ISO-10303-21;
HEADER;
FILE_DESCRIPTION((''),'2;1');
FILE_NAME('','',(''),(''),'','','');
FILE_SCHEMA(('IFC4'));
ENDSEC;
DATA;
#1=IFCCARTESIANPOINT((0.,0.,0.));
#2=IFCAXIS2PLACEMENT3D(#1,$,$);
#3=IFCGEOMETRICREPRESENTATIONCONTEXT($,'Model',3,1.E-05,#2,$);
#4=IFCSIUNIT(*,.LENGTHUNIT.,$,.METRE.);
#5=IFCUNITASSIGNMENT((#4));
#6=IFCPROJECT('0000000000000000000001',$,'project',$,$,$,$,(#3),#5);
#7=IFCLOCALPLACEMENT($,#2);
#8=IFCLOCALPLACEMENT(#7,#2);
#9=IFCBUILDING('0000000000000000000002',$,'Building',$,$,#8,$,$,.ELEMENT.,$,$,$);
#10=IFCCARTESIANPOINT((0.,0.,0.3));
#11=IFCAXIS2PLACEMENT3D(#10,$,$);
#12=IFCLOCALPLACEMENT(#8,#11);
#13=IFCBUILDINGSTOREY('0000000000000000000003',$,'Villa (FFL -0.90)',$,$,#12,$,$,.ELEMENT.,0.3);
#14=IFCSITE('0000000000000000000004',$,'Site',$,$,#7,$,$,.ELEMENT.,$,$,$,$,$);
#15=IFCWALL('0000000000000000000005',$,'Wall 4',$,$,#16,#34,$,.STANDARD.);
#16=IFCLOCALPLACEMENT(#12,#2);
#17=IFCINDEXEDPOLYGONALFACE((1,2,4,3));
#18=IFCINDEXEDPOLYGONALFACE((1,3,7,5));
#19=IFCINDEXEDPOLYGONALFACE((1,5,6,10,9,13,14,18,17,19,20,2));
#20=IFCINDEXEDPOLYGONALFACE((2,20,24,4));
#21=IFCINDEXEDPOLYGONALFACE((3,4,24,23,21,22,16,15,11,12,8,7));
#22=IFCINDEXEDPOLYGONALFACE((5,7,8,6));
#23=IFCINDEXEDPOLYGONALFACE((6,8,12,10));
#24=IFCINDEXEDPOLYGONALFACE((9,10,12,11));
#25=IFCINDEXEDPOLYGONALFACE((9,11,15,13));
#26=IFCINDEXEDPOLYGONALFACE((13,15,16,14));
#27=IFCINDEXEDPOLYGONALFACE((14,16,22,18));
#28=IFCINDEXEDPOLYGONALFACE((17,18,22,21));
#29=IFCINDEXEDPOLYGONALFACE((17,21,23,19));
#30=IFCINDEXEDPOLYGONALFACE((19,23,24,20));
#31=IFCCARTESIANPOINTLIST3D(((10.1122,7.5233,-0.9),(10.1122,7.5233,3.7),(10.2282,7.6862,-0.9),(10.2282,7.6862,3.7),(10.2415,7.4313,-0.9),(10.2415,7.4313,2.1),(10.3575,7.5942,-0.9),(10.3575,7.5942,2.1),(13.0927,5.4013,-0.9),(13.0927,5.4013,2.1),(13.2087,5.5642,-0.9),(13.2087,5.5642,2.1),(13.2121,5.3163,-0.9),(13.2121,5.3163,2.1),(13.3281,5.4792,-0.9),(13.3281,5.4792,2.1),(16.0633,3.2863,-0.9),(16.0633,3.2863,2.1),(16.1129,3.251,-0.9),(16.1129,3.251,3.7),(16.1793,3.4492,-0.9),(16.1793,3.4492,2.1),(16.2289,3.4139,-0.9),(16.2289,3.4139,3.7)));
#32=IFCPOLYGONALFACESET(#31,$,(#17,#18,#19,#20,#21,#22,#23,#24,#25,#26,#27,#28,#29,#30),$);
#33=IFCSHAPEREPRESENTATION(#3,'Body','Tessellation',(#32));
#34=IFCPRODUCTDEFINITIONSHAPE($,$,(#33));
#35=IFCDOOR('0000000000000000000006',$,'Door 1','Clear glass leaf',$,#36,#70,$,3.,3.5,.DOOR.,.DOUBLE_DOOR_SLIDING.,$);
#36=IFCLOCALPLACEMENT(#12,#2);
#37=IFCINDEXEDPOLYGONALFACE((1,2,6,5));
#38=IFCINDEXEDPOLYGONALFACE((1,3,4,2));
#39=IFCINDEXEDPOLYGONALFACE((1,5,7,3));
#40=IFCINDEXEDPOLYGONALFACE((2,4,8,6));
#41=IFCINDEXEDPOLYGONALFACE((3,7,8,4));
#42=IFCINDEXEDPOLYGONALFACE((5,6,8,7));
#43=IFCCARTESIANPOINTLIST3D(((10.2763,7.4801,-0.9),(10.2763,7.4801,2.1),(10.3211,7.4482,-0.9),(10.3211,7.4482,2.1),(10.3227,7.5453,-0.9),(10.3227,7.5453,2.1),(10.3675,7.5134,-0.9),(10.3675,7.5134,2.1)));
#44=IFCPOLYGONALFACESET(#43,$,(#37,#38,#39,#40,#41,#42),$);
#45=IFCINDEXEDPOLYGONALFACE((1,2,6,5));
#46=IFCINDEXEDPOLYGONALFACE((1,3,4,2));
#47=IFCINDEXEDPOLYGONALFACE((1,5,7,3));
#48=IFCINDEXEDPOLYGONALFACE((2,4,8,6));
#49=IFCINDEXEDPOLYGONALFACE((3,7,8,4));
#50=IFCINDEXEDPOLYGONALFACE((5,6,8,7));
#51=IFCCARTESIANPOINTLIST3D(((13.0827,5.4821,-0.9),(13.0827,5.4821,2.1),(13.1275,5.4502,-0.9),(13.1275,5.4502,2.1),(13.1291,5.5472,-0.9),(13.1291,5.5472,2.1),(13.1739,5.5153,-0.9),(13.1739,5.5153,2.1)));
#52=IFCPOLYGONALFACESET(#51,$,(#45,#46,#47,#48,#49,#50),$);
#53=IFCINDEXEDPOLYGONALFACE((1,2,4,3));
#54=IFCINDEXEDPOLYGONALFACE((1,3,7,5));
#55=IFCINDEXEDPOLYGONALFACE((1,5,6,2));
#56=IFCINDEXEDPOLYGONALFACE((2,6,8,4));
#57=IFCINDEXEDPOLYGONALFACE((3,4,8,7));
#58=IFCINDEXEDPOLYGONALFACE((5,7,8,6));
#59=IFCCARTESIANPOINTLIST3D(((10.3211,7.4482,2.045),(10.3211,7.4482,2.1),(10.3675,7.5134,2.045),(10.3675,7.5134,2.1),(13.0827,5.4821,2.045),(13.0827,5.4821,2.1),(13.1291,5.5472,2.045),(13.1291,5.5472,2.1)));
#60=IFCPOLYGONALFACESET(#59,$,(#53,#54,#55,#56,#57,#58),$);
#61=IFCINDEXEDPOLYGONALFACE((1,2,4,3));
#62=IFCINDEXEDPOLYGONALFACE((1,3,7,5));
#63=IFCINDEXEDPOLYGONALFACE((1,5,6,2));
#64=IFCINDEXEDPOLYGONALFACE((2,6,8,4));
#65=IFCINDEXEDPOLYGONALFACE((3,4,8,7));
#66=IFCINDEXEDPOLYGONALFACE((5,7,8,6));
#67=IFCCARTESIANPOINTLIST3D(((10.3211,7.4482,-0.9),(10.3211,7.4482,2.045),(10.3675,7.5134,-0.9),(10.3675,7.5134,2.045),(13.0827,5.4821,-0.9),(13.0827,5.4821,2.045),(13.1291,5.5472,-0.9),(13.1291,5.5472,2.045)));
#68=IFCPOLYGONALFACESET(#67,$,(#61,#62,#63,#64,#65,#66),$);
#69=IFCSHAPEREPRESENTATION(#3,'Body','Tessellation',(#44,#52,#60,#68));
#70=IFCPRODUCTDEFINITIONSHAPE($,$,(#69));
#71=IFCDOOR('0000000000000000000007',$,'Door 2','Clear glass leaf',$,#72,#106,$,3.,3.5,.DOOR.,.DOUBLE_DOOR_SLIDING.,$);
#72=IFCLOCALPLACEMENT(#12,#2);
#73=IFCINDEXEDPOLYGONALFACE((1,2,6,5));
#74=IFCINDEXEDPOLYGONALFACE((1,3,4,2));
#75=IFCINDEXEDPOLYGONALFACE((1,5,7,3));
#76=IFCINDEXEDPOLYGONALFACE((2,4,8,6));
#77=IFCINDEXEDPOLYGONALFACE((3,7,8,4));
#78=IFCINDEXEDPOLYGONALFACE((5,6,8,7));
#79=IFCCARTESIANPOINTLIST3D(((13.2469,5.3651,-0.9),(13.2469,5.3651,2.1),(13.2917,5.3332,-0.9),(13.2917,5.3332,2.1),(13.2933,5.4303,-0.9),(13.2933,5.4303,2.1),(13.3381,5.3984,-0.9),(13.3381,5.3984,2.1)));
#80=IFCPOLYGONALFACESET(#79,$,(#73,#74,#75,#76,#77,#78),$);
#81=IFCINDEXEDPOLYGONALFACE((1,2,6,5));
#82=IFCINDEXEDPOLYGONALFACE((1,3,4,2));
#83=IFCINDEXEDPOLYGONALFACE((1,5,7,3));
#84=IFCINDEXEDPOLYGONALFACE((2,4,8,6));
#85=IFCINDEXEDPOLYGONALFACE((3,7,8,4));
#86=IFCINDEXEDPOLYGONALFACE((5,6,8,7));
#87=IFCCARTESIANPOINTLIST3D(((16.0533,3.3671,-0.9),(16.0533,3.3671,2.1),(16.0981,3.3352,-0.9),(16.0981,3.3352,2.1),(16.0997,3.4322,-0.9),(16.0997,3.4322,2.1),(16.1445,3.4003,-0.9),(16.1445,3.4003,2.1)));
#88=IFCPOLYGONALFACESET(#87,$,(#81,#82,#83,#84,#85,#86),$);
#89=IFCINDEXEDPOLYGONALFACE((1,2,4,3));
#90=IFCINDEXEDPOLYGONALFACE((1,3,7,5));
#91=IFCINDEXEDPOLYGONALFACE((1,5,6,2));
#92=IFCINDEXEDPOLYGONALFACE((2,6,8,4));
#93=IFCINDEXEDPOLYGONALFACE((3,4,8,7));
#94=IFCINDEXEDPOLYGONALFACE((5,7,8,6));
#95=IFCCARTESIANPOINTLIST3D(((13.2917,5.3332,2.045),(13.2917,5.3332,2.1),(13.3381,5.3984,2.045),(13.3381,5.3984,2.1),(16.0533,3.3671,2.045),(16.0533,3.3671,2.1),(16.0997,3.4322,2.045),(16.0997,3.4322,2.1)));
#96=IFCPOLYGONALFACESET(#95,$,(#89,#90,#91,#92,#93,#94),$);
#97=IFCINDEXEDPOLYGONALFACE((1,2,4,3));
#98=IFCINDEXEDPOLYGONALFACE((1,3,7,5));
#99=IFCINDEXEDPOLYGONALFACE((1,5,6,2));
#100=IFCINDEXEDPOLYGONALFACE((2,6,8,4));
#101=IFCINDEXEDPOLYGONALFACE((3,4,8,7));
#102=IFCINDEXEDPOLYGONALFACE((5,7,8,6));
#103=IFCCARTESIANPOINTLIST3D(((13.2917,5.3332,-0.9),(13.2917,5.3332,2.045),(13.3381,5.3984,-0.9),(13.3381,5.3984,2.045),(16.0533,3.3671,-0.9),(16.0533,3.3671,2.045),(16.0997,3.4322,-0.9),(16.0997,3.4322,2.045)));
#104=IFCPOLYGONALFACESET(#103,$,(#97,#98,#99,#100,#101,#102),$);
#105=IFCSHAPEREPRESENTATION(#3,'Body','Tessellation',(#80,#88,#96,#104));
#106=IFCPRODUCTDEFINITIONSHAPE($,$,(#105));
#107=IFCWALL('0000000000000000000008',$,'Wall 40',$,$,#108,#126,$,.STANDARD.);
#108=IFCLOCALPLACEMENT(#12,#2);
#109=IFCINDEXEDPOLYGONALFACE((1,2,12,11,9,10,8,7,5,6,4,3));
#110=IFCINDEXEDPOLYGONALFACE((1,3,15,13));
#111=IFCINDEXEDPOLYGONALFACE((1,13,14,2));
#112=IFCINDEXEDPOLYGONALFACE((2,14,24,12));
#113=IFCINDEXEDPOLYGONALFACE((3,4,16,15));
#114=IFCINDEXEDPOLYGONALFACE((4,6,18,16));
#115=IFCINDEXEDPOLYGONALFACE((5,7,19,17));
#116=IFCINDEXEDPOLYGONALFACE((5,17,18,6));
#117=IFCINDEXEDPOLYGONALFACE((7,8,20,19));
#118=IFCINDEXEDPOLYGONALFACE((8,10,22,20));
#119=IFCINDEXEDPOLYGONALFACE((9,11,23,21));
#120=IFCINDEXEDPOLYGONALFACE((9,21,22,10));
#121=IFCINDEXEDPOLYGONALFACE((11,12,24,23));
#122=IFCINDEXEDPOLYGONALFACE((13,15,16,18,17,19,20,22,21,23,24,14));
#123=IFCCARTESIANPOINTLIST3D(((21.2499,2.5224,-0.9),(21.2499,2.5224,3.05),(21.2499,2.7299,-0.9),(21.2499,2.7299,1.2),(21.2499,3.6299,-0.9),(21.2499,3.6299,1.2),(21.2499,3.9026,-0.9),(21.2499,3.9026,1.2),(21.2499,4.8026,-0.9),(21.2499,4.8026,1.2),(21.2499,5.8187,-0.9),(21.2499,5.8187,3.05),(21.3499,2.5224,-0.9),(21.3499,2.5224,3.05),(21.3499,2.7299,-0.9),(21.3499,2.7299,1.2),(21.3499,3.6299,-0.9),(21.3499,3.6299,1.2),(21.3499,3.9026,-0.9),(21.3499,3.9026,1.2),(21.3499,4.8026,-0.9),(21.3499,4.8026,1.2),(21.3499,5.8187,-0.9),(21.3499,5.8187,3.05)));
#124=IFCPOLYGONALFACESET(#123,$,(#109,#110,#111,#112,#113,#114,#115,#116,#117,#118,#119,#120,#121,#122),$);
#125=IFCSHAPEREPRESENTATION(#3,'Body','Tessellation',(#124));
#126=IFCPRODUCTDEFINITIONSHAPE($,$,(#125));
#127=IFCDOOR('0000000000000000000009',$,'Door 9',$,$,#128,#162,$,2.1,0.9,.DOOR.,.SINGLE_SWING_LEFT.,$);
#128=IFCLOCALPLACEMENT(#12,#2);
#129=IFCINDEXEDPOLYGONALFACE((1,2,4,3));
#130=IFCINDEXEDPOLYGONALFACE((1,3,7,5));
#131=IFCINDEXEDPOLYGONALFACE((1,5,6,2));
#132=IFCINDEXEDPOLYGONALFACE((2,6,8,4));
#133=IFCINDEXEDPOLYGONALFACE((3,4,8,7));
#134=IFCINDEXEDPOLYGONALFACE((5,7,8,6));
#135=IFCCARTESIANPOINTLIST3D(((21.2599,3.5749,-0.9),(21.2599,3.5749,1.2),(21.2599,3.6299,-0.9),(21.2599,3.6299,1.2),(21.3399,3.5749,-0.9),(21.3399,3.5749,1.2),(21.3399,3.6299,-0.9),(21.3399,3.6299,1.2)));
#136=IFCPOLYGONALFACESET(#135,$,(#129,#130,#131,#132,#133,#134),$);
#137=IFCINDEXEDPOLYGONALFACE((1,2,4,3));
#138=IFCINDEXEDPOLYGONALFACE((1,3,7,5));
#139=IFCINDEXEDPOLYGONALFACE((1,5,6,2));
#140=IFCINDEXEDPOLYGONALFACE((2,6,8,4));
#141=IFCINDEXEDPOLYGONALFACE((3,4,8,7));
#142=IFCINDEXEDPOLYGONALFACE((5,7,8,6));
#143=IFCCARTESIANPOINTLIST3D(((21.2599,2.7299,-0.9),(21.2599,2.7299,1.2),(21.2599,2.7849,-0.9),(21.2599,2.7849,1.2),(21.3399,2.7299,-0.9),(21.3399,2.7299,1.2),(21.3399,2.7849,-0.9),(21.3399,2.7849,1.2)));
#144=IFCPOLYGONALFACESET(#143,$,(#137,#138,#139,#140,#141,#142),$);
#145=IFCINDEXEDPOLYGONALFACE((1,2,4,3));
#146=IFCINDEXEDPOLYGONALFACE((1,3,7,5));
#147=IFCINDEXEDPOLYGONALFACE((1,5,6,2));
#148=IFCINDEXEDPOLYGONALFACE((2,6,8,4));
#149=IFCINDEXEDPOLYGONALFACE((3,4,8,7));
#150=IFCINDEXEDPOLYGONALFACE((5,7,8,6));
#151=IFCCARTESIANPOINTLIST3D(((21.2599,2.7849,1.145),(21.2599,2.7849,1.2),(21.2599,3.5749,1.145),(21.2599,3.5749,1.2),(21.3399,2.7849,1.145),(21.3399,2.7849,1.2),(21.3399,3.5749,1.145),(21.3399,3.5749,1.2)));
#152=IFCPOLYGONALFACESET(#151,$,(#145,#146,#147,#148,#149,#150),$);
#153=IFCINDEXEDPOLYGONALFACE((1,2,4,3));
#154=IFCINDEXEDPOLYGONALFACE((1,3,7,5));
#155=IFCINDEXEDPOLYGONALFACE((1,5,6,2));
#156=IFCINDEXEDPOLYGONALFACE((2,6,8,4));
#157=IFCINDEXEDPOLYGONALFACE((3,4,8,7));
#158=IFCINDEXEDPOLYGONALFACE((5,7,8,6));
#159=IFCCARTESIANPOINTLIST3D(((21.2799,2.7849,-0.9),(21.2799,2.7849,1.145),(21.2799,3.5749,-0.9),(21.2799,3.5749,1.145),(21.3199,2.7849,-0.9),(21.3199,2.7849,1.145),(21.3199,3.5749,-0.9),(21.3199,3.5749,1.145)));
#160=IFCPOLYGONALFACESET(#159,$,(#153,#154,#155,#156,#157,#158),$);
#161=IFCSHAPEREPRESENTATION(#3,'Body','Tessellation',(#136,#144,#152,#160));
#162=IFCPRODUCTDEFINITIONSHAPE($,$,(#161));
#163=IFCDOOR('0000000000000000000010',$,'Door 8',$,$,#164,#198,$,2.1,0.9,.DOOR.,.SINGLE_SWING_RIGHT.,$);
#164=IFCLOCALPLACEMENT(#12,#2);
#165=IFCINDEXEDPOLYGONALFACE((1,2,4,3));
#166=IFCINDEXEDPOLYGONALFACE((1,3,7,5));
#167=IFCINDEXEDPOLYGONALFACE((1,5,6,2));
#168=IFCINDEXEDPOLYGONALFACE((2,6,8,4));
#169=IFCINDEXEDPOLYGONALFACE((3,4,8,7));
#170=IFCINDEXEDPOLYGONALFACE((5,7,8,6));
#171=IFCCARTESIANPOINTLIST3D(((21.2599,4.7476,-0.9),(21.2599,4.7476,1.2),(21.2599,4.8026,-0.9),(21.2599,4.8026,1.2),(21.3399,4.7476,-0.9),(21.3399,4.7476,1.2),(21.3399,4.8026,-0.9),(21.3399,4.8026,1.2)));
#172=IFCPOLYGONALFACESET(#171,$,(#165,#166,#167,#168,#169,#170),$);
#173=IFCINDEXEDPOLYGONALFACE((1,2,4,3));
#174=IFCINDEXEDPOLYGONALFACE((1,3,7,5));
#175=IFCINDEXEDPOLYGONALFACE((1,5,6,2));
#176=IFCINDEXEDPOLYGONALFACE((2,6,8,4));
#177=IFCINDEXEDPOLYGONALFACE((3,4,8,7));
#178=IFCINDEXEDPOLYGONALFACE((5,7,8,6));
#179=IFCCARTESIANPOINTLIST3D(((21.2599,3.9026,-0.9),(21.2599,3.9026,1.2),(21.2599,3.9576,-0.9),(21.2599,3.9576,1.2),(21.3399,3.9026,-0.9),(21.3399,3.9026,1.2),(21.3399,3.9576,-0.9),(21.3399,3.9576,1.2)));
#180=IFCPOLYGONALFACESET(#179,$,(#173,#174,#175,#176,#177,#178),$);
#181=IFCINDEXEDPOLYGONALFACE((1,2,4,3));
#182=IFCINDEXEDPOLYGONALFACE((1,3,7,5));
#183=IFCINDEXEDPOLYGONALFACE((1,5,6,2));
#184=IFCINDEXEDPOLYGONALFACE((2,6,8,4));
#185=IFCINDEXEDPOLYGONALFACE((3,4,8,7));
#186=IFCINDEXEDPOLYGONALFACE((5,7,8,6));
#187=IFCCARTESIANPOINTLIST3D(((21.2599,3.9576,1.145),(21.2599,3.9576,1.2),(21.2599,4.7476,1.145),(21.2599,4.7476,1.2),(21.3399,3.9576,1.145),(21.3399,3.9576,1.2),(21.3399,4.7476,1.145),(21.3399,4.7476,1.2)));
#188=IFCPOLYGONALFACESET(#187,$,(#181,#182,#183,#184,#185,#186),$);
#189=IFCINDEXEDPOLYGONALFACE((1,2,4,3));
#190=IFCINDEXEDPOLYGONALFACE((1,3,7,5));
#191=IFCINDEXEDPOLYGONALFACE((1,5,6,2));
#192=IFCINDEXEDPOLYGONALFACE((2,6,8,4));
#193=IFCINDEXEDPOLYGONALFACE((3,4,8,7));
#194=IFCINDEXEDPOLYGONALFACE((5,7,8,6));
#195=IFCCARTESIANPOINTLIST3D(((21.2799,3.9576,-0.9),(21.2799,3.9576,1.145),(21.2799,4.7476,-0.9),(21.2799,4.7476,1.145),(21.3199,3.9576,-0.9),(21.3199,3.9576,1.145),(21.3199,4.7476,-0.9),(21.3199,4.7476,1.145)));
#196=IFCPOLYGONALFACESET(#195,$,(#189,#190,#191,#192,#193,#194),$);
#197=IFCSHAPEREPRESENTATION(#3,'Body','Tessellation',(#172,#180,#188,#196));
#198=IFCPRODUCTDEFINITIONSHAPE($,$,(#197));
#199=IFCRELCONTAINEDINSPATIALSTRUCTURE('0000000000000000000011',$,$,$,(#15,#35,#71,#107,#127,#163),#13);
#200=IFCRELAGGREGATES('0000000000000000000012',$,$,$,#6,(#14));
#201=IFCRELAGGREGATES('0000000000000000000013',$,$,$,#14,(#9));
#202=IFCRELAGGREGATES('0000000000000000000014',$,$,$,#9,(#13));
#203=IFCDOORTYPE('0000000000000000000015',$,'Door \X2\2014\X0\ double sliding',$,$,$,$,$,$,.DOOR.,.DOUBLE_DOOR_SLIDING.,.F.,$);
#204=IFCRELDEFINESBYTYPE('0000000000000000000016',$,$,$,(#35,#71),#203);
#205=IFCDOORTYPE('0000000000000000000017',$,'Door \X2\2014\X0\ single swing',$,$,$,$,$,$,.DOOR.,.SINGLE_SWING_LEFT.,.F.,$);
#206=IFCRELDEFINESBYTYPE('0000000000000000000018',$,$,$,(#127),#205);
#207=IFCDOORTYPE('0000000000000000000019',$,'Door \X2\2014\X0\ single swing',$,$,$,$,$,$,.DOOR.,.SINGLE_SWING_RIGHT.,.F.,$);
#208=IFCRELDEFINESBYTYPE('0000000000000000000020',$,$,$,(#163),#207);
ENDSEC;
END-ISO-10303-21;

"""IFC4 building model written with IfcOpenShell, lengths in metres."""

from ifc_helpers import new_model, si_unit, frame, frame_2d, origin, place, context, project, spatial, rectangle, extrude, type_object, element, fill, save


model = new_model("IFC4")

# Units and contexts
model_context = context("Model", 3, precision=1e-05, world=origin())
ifc_project = project(units=[si_unit("LENGTHUNIT", "METRE")], contexts=[model_context])

# Site, building, storey
site_placement = place(None, origin())
site = spatial("IfcSite", under=ifc_project, at=site_placement, Name="Site", CompositionType="ELEMENT")
building_placement = place(site_placement, origin())
building = spatial("IfcBuilding", under=site, at=building_placement, Name="Building", CompositionType="ELEMENT")
storey_placement = place(building_placement, frame((0.0, 0.0, 0.3)))
storey = spatial("IfcBuildingStorey", under=building, at=storey_placement, Name="Villa (FFL -0.90)", CompositionType="ELEMENT", Elevation=0.3)

# Walls, openings, doors
wall_1_placement = place(storey_placement, frame((10.1702, 7.6048, -0.9), z_axis=(0.0, 0.0, 1.0), x_axis=(0.814622, -0.579992, 0.0)))
wall_1 = element("IfcWall", 1, at=wall_1_placement, inside=storey, Name="Wall 4", PredefinedType="STANDARD", context=model_context, shape_type="SweptSolid", body=[
    extrude(rectangle(XDim=7.3662, YDim=0.2, at=frame_2d((3.6831, 0.0))), origin(), (0.0, 0.0, 1.0), 4.6),
])
opening_1_placement = place(storey_placement, frame((10.2995, 7.5127, -0.9), z_axis=(0.0, 0.0, 1.0), x_axis=(0.814622, -0.579992, 0.0)))
opening_1 = element("IfcOpeningElement", 2, at=opening_1_placement, cuts=wall_1, PredefinedType="OPENING", context=model_context, shape_type="SweptSolid", body=[
    extrude(rectangle(XDim=3.5, YDim=0.26, at=frame_2d((1.75, 0.0))), origin(), (0.0, 0.0, 1.0), 3.0),
])
opening_2_placement = place(storey_placement, frame((13.2701, 5.3977, -0.9), z_axis=(0.0, 0.0, 1.0), x_axis=(0.814622, -0.579992, 0.0)))
opening_2 = element("IfcOpeningElement", 3, at=opening_2_placement, cuts=wall_1, PredefinedType="OPENING", context=model_context, shape_type="SweptSolid", body=[
    extrude(rectangle(XDim=3.5, YDim=0.26, at=frame_2d((1.75, 0.0))), origin(), (0.0, 0.0, 1.0), 3.0),
])
door_type_1 = type_object("IfcDoorType", Name="Door — double sliding", OperationType="DOUBLE_DOOR_SLIDING", ParameterTakesPrecedence=False, PredefinedType="DOOR")
door_1_placement = place(storey_placement, frame((10.2995, 7.5127, -0.9), z_axis=(0.0, 0.0, 1.0), x_axis=(0.814622, -0.579992, 0.0)))
door_1 = element("IfcDoor", 4, at=door_1_placement, inside=storey, type_object=door_type_1, Name="Door 1", Description="Clear glass leaf", OperationType="DOUBLE_DOOR_SLIDING", OverallHeight=3.0, OverallWidth=3.5, PredefinedType="DOOR", context=model_context, shape_type="SweptSolid", body=[
    extrude(rectangle(XDim=0.055, YDim=0.08, at=frame_2d((0.0275, 0.0))), origin(), (0.0, 0.0, 1.0), 3.0),
    extrude(rectangle(XDim=0.055, YDim=0.08, at=frame_2d((3.4725, 0.0))), origin(), (0.0, 0.0, 1.0), 3.0),
    extrude(rectangle(XDim=3.39, YDim=0.08, at=frame_2d((1.75, 0.0))), frame((0.0, 0.0, 2.945)), (0.0, 0.0, 1.0), 0.055),
    extrude(rectangle(XDim=3.39, YDim=0.08, at=frame_2d((1.75, 0.0))), origin(), (0.0, 0.0, 1.0), 2.945),
])
fill(opening_1, door_1)
door_2_placement = place(storey_placement, frame((13.2701, 5.3977, -0.9), z_axis=(0.0, 0.0, 1.0), x_axis=(0.814622, -0.579992, 0.0)))
door_2 = element("IfcDoor", 5, at=door_2_placement, inside=storey, type_object=door_type_1, Name="Door 2", Description="Clear glass leaf", OperationType="DOUBLE_DOOR_SLIDING", OverallHeight=3.0, OverallWidth=3.5, PredefinedType="DOOR", context=model_context, shape_type="SweptSolid", body=[
    extrude(rectangle(XDim=0.055, YDim=0.08, at=frame_2d((0.0275, 0.0))), origin(), (0.0, 0.0, 1.0), 3.0),
    extrude(rectangle(XDim=0.055, YDim=0.08, at=frame_2d((3.4725, 0.0))), origin(), (0.0, 0.0, 1.0), 3.0),
    extrude(rectangle(XDim=3.39, YDim=0.08, at=frame_2d((1.75, 0.0))), frame((0.0, 0.0, 2.945)), (0.0, 0.0, 1.0), 0.055),
    extrude(rectangle(XDim=3.39, YDim=0.08, at=frame_2d((1.75, 0.0))), origin(), (0.0, 0.0, 1.0), 2.945),
])
fill(opening_2, door_2)
wall_2_placement = place(storey_placement, frame((21.2999, 5.8187, -0.9), z_axis=(0.0, 0.0, 1.0), x_axis=(0.0, -1.0, 0.0)))
wall_2 = element("IfcWall", 6, at=wall_2_placement, inside=storey, Name="Wall 40", PredefinedType="STANDARD", context=model_context, shape_type="SweptSolid", body=[
    extrude(rectangle(XDim=3.2963, YDim=0.1, at=frame_2d((1.6482, 0.0))), origin(), (0.0, 0.0, 1.0), 3.95),
])
opening_3_placement = place(storey_placement, frame((21.2999, 4.8026, -0.9), z_axis=(0.0, 0.0, 1.0), x_axis=(0.0, -1.0, 0.0)))
opening_3 = element("IfcOpeningElement", 7, at=opening_3_placement, cuts=wall_2, PredefinedType="OPENING", context=model_context, shape_type="SweptSolid", body=[
    extrude(rectangle(XDim=0.9, YDim=0.16, at=frame_2d((0.45, 0.0))), origin(), (0.0, 0.0, 1.0), 2.1),
])
opening_4_placement = place(storey_placement, frame((21.2999, 3.6299, -0.9), z_axis=(0.0, 0.0, 1.0), x_axis=(0.0, -1.0, 0.0)))
opening_4 = element("IfcOpeningElement", 8, at=opening_4_placement, cuts=wall_2, PredefinedType="OPENING", context=model_context, shape_type="SweptSolid", body=[
    extrude(rectangle(XDim=0.9, YDim=0.16, at=frame_2d((0.45, 0.0))), origin(), (0.0, 0.0, 1.0), 2.1),
])
door_type_2 = type_object("IfcDoorType", Name="Door — single swing", OperationType="SINGLE_SWING_LEFT", ParameterTakesPrecedence=False, PredefinedType="DOOR")
door_3_placement = place(storey_placement, frame((21.2999, 3.6299, -0.9), z_axis=(0.0, 0.0, 1.0), x_axis=(0.0, -1.0, 0.0)))
door_3 = element("IfcDoor", 9, at=door_3_placement, inside=storey, type_object=door_type_2, Name="Door 9", OperationType="SINGLE_SWING_LEFT", OverallHeight=2.1, OverallWidth=0.9, PredefinedType="DOOR", context=model_context, shape_type="SweptSolid", body=[
    extrude(rectangle(XDim=0.055, YDim=0.08, at=frame_2d((0.0275, 0.0))), origin(), (0.0, 0.0, 1.0), 2.1),
    extrude(rectangle(XDim=0.055, YDim=0.08, at=frame_2d((0.8725, 0.0))), origin(), (0.0, 0.0, 1.0), 2.1),
    extrude(rectangle(XDim=0.79, YDim=0.08, at=frame_2d((0.45, 0.0))), frame((0.0, 0.0, 2.045)), (0.0, 0.0, 1.0), 0.055),
    extrude(rectangle(XDim=0.79, YDim=0.04, at=frame_2d((0.45, 0.0))), origin(), (0.0, 0.0, 1.0), 2.045),
])
fill(opening_4, door_3)
door_type_3 = type_object("IfcDoorType", Name="Door — single swing", OperationType="SINGLE_SWING_RIGHT", ParameterTakesPrecedence=False, PredefinedType="DOOR")
door_4_placement = place(storey_placement, frame((21.2999, 4.8026, -0.9), z_axis=(0.0, 0.0, 1.0), x_axis=(0.0, -1.0, 0.0)))
door_4 = element("IfcDoor", 10, at=door_4_placement, inside=storey, type_object=door_type_3, Name="Door 8", OperationType="SINGLE_SWING_RIGHT", OverallHeight=2.1, OverallWidth=0.9, PredefinedType="DOOR", context=model_context, shape_type="SweptSolid", body=[
    extrude(rectangle(XDim=0.055, YDim=0.08, at=frame_2d((0.0275, 0.0))), origin(), (0.0, 0.0, 1.0), 2.1),
    extrude(rectangle(XDim=0.055, YDim=0.08, at=frame_2d((0.8725, 0.0))), origin(), (0.0, 0.0, 1.0), 2.1),
    extrude(rectangle(XDim=0.79, YDim=0.08, at=frame_2d((0.45, 0.0))), frame((0.0, 0.0, 2.045)), (0.0, 0.0, 1.0), 0.055),
    extrude(rectangle(XDim=0.79, YDim=0.04, at=frame_2d((0.45, 0.0))), origin(), (0.0, 0.0, 1.0), 2.045),
])
fill(opening_3, door_4)

save(model, "model.ifc")
